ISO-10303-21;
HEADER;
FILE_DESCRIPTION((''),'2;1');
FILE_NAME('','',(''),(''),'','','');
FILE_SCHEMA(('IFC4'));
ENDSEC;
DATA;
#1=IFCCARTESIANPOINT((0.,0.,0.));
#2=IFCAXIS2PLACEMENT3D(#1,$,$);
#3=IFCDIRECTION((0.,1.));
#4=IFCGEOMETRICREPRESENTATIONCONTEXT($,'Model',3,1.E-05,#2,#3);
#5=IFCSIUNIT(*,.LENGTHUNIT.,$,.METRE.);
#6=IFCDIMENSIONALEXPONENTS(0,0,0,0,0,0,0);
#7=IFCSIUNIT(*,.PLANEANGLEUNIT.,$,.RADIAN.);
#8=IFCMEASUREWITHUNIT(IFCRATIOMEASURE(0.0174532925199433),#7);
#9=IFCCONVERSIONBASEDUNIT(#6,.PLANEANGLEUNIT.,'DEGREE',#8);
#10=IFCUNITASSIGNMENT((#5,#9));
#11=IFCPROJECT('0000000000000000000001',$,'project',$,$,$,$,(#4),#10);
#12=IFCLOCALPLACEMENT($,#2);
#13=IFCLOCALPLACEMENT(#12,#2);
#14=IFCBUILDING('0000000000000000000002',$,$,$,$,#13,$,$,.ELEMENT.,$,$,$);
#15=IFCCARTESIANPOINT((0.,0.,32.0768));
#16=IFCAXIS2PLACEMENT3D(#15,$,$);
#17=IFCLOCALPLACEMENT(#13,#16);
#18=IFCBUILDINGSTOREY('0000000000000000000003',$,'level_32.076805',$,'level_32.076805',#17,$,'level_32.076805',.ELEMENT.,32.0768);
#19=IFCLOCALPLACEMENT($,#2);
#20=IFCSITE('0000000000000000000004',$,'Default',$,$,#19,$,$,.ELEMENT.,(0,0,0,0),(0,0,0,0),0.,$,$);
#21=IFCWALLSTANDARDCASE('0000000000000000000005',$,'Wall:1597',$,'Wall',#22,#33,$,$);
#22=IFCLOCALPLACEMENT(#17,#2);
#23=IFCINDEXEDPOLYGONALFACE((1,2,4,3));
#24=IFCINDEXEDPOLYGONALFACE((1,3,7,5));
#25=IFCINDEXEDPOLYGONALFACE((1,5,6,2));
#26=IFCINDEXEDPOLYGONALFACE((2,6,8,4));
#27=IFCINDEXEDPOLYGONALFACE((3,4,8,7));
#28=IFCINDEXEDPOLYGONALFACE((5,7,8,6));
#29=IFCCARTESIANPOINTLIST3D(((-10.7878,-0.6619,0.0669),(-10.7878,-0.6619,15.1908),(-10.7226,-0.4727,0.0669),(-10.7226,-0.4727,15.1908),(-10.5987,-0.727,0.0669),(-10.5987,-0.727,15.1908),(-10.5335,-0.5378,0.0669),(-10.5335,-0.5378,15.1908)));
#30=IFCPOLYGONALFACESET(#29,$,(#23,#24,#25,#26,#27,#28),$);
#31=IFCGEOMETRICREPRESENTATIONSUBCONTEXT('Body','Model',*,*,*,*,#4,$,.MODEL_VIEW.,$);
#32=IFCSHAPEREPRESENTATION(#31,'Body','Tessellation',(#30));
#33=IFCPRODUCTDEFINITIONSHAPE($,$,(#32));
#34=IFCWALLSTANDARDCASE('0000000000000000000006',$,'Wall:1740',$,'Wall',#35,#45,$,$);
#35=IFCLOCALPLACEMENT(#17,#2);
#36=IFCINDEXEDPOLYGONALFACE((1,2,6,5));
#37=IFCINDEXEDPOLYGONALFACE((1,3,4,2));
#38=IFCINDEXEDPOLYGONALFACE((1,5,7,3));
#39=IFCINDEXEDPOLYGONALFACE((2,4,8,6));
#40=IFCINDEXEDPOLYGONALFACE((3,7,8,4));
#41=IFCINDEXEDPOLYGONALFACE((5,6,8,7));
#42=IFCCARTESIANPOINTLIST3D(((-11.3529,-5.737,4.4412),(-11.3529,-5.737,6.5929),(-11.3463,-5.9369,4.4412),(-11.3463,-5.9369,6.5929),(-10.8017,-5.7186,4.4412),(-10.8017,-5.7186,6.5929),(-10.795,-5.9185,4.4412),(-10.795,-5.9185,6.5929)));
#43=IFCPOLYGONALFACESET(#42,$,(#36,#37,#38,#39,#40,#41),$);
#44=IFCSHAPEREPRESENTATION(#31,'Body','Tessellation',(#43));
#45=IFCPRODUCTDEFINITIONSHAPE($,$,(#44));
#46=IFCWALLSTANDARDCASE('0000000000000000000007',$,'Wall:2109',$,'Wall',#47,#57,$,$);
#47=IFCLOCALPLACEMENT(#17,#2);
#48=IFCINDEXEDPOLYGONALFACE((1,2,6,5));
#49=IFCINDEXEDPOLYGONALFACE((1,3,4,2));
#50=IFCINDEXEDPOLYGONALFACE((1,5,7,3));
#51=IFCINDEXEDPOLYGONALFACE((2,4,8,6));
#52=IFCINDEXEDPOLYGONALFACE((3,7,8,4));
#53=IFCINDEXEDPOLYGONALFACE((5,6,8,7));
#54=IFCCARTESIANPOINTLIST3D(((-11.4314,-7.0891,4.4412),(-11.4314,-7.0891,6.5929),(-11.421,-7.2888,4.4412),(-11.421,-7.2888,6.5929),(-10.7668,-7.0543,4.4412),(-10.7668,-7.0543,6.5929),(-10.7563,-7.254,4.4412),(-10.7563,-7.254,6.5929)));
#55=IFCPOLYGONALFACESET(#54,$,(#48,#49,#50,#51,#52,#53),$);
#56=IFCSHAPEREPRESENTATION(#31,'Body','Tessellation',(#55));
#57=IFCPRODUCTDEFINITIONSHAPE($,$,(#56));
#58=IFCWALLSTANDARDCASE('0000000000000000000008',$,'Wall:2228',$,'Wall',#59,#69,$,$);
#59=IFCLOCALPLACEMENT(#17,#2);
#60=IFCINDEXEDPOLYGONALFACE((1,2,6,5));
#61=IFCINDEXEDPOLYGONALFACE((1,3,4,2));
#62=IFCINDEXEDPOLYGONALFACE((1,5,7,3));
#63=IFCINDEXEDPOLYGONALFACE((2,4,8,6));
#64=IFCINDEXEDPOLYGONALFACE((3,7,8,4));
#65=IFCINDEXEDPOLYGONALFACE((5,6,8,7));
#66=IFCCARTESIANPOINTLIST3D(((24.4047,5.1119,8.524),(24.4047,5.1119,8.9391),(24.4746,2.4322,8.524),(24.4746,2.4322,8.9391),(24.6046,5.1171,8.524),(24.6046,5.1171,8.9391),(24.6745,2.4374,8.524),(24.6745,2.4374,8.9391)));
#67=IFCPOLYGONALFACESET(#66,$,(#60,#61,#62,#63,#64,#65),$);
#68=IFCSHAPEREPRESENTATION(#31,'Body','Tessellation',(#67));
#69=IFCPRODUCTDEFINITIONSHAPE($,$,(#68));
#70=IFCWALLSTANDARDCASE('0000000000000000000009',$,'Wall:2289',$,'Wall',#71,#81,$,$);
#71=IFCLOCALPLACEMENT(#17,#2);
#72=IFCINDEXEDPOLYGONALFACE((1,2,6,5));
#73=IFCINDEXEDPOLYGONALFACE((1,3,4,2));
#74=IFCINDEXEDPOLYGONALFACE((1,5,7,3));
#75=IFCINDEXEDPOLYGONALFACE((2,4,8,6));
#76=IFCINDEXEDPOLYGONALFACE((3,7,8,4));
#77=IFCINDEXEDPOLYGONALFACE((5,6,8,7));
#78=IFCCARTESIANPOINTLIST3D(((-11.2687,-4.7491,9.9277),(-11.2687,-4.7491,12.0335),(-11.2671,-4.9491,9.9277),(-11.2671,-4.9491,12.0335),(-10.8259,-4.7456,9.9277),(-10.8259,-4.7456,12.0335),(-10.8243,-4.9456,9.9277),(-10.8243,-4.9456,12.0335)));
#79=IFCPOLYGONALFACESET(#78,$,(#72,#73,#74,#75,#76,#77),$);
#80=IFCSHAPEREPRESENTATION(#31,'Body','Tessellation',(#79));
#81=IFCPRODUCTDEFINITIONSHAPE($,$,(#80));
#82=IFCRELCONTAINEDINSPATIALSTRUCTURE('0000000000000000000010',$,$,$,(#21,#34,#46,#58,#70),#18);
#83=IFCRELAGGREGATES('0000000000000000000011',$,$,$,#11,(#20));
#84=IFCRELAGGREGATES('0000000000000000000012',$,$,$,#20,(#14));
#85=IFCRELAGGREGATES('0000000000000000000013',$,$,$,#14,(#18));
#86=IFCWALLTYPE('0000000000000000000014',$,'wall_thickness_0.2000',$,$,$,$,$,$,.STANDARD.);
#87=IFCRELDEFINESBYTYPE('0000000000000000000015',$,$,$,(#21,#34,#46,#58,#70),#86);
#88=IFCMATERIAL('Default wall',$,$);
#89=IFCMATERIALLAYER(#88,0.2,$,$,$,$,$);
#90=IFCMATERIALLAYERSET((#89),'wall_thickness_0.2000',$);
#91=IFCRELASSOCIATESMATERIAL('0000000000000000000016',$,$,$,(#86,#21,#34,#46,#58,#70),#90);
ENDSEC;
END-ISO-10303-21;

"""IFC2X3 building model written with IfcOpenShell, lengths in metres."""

from ifc_helpers import new_model, entity, si_unit, converted_unit, direction, frame, origin, place, context, subcontext, project, spatial, polyline, outline, extrude, material, layer, layer_set, layer_usage, type_object, element, save


model = new_model("IFC2X3")

# Units and contexts
model_context = context("Model", 3, precision=1e-05, world=origin(), true_north=direction((0.0, 1.0)))
body_context = subcontext(model_context, "Body", "Model", "MODEL_VIEW")
ifc_project = project(units=[si_unit("LENGTHUNIT", "METRE"), converted_unit("PLANEANGLEUNIT", "DEGREE", entity("IfcRatioMeasure", 0.0174532925199433), si_unit("PLANEANGLEUNIT", "RADIAN"), dimensions=[0, 0, 0, 0, 0, 0, 0])], contexts=[model_context])

# Site, building, storey
site_placement = place(None, origin())
site = spatial("IfcSite", under=ifc_project, at=site_placement, Name="Default", CompositionType="ELEMENT", RefLatitude=(0, 0, 0, 0), RefLongitude=(0, 0, 0, 0), RefElevation=0.0)
placement_1 = place(None, origin())
building_placement = place(placement_1, origin())
building = spatial("IfcBuilding", under=site, at=building_placement, CompositionType="ELEMENT")
storey_placement = place(building_placement, frame((0.0, 0.0, 32.0768)))
storey = spatial("IfcBuildingStorey", under=building, at=storey_placement, Name="level_32.076805", ObjectType="level_32.076805", LongName="level_32.076805", CompositionType="ELEMENT", Elevation=32.0768)

# Walls
ifc_material = material(Name="Default wall")
ifc_layer = layer(ifc_material, 0.2)
ifc_layer_set = layer_set([ifc_layer], Name="wall_thickness_0.2000")
ifc_layer_usage = layer_usage(ifc_layer_set, "AXIS2", "POSITIVE", -0.1)
wall_type = type_object("IfcWallType", Name="wall_thickness_0.2000", PredefinedType="STANDARD", material=ifc_layer_set)
placement_2 = place(building_placement, frame((0.0, 0.0, 32.1437)))
wall_1_placement = place(placement_2, frame((-10.6281, -0.5052, 0.0), z_axis=(0.0, 0.0, 1.0), x_axis=(-0.32556, -0.945521, 0.0)))
element("IfcWallStandardCase", 1, at=wall_1_placement, inside=storey, type_object=wall_type, material=ifc_layer_usage, Name="Wall:1597", ObjectType="Wall", context=body_context, shape_type="SweptSolid", body=[
    extrude(outline(polyline([(0.2001, -0.1), (0.2001, 0.1), (0.0, 0.1), (0.0, -0.1), (0.2001, -0.1)])), origin(), (0.0, 0.0, 1.0), 15.1239),
])
placement_3 = place(building_placement, frame((0.0, 0.0, 36.518)))
wall_2_placement = place(placement_3, frame((-10.7983, -5.8186, 0.0), z_axis=(0.0, 0.0, 1.0), x_axis=(-0.999447, -0.033243, 0.0)))
element("IfcWallStandardCase", 2, at=wall_2_placement, inside=storey, type_object=wall_type, material=ifc_layer_usage, Name="Wall:1740", ObjectType="Wall", context=body_context, shape_type="SweptSolid", body=[
    extrude(outline(polyline([(0.5516, -0.1), (0.5516, 0.1), (0.0, 0.1), (0.0, -0.1), (0.5516, -0.1)])), origin(), (0.0, 0.0, 1.0), 2.1518),
])
placement_4 = place(building_placement, frame((0.0, 0.0, 36.518)))
wall_3_placement = place(placement_4, frame((-10.7616, -7.1541, 0.0), z_axis=(0.0, 0.0, 1.0), x_axis=(-0.998631, -0.052304, 0.0)))
element("IfcWallStandardCase", 3, at=wall_3_placement, inside=storey, type_object=wall_type, material=ifc_layer_usage, Name="Wall:2109", ObjectType="Wall", context=body_context, shape_type="SweptSolid", body=[
    extrude(outline(polyline([(0.6656, -0.1), (0.6656, 0.1), (0.0, 0.1), (0.0, -0.1), (0.6656, -0.1)])), origin(), (0.0, 0.0, 1.0), 2.1518),
])
placement_5 = place(building_placement, frame((0.0, 0.0, 40.6008)))
wall_4_placement = place(placement_5, frame((24.5047, 5.1145, 0.0), z_axis=(0.0, 0.0, 1.0), x_axis=(0.026062, -0.99966, 0.0)))
element("IfcWallStandardCase", 4, at=wall_4_placement, inside=storey, type_object=wall_type, material=ifc_layer_usage, Name="Wall:2228", ObjectType="Wall", context=body_context, shape_type="SweptSolid", body=[
    extrude(outline(polyline([(2.6806, -0.1), (2.6806, 0.1), (0.0, 0.1), (0.0, -0.1), (2.6806, -0.1)])), origin(), (0.0, 0.0, 1.0), 0.4152),
])
placement_6 = place(building_placement, frame((0.0, 0.0, 42.0045)))
wall_5_placement = place(placement_6, frame((-10.8251, -4.8456, 0.0), z_axis=(0.0, 0.0, 1.0), x_axis=(-0.999968, -0.00805, 0.0)))
element("IfcWallStandardCase", 5, at=wall_5_placement, inside=storey, type_object=wall_type, material=ifc_layer_usage, Name="Wall:2289", ObjectType="Wall", context=body_context, shape_type="SweptSolid", body=[
    extrude(outline(polyline([(0.4428, -0.1), (0.4428, 0.1), (0.0, 0.1), (0.0, -0.1), (0.4428, -0.1)])), origin(), (0.0, 0.0, 1.0), 2.1058),
])

save(model, "model.ifc")
